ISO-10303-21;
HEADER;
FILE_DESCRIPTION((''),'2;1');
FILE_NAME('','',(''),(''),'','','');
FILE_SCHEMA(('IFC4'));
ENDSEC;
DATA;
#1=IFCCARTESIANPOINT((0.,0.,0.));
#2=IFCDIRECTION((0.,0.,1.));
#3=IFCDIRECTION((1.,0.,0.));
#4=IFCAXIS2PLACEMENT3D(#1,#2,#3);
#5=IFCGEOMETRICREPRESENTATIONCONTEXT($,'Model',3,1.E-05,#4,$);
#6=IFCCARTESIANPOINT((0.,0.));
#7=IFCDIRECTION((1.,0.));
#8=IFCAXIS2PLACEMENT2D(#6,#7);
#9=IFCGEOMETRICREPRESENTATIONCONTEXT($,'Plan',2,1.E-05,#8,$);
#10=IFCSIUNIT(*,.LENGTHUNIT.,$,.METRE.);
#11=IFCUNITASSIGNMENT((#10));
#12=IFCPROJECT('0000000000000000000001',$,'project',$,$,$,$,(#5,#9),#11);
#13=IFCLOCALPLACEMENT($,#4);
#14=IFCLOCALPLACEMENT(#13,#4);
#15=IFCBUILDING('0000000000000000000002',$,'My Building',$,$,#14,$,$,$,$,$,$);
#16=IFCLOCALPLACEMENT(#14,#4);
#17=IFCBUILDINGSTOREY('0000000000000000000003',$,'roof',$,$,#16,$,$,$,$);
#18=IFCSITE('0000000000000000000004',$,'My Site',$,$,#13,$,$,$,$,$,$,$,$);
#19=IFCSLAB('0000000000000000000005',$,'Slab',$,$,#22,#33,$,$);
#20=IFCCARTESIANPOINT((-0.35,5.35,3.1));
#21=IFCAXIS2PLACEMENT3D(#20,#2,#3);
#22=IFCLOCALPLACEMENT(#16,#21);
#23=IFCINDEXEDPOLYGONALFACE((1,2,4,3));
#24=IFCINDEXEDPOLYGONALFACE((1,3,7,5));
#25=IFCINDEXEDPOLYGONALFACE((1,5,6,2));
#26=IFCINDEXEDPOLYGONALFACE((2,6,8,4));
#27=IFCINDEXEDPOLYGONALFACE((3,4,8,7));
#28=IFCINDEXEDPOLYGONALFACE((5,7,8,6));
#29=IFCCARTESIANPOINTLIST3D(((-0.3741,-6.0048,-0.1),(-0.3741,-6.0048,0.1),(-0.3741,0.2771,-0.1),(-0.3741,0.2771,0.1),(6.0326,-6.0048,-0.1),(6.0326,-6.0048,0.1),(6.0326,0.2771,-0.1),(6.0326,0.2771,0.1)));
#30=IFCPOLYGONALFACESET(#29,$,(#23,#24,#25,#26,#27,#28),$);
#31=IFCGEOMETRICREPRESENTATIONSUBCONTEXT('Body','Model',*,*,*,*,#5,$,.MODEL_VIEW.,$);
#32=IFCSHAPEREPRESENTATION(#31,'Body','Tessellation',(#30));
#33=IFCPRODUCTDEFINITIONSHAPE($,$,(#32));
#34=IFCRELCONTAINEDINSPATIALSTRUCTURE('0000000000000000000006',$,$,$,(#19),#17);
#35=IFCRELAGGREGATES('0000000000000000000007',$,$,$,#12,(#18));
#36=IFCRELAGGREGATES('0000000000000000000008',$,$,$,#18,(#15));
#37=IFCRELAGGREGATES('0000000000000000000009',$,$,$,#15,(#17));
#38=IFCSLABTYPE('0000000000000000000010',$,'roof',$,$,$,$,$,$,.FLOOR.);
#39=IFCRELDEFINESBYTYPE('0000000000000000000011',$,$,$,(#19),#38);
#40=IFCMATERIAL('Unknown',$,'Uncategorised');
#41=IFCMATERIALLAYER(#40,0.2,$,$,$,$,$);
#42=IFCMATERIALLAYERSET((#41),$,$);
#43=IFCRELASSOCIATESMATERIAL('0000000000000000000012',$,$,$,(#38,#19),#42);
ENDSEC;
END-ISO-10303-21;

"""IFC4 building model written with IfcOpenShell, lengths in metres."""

from ifc_helpers import new_model, si_unit, frame, origin_with_axes, origin_2d_with_axis, place, context, subcontext, project, spatial, indexed_curve, outline, extrude, material, layer, layer_set, layer_usage, type_object, element, save


model = new_model("IFC4")

# Units and contexts
model_context = context("Model", 3, precision=1e-05, world=origin_with_axes())
plan_context = context("Plan", 2, precision=1e-05, world=origin_2d_with_axis())
body_context_1 = subcontext(model_context, "Body", "Model", "MODEL_VIEW")
ifc_project = project(units=[si_unit("LENGTHUNIT", "METRE")], contexts=[model_context, plan_context])

# Site, building, storey
site_placement = place(None, origin_with_axes())
site = spatial("IfcSite", under=ifc_project, at=site_placement, Name="My Site")
building_placement = place(site_placement, origin_with_axes())
building = spatial("IfcBuilding", under=site, at=building_placement, Name="My Building")
storey_placement = place(building_placement, origin_with_axes())
storey = spatial("IfcBuildingStorey", under=building, at=storey_placement, Name="roof")

# Slab
ifc_material = material(Name="Unknown", Category="Uncategorised")
ifc_layer_1 = layer(ifc_material, 0.2)
ifc_layer_set_1 = layer_set([ifc_layer_1])
ifc_layer_usage_1 = layer_usage(ifc_layer_set_1, "AXIS3", "POSITIVE", -0.1)
slab_type = type_object("IfcSlabType", Name="roof", PredefinedType="FLOOR", material=ifc_layer_set_1)
slab_placement = place(storey_placement, frame((-0.35, 5.35, 3.1), z_axis=(0.0, 0.0, 1.0), x_axis=(1.0, 0.0, 0.0)))
element("IfcSlab", 1, at=slab_placement, inside=storey, type_object=slab_type, material=ifc_layer_usage_1, Name="Slab", context=body_context_1, shape_type="SweptSolid", body=[
    extrude(outline(indexed_curve([(-0.3741, -6.0048), (6.0326, -6.0048), (6.0326, 0.2771), (-0.3741, 0.2771), (-0.3741, -6.0048)])), frame((0.0, 0.0, -0.1), z_axis=(0.0, 0.0, 1.0), x_axis=(1.0, 0.0, 0.0)), (0.0, 0.0, 1.0), 0.2),
])

save(model, "model.ifc")
